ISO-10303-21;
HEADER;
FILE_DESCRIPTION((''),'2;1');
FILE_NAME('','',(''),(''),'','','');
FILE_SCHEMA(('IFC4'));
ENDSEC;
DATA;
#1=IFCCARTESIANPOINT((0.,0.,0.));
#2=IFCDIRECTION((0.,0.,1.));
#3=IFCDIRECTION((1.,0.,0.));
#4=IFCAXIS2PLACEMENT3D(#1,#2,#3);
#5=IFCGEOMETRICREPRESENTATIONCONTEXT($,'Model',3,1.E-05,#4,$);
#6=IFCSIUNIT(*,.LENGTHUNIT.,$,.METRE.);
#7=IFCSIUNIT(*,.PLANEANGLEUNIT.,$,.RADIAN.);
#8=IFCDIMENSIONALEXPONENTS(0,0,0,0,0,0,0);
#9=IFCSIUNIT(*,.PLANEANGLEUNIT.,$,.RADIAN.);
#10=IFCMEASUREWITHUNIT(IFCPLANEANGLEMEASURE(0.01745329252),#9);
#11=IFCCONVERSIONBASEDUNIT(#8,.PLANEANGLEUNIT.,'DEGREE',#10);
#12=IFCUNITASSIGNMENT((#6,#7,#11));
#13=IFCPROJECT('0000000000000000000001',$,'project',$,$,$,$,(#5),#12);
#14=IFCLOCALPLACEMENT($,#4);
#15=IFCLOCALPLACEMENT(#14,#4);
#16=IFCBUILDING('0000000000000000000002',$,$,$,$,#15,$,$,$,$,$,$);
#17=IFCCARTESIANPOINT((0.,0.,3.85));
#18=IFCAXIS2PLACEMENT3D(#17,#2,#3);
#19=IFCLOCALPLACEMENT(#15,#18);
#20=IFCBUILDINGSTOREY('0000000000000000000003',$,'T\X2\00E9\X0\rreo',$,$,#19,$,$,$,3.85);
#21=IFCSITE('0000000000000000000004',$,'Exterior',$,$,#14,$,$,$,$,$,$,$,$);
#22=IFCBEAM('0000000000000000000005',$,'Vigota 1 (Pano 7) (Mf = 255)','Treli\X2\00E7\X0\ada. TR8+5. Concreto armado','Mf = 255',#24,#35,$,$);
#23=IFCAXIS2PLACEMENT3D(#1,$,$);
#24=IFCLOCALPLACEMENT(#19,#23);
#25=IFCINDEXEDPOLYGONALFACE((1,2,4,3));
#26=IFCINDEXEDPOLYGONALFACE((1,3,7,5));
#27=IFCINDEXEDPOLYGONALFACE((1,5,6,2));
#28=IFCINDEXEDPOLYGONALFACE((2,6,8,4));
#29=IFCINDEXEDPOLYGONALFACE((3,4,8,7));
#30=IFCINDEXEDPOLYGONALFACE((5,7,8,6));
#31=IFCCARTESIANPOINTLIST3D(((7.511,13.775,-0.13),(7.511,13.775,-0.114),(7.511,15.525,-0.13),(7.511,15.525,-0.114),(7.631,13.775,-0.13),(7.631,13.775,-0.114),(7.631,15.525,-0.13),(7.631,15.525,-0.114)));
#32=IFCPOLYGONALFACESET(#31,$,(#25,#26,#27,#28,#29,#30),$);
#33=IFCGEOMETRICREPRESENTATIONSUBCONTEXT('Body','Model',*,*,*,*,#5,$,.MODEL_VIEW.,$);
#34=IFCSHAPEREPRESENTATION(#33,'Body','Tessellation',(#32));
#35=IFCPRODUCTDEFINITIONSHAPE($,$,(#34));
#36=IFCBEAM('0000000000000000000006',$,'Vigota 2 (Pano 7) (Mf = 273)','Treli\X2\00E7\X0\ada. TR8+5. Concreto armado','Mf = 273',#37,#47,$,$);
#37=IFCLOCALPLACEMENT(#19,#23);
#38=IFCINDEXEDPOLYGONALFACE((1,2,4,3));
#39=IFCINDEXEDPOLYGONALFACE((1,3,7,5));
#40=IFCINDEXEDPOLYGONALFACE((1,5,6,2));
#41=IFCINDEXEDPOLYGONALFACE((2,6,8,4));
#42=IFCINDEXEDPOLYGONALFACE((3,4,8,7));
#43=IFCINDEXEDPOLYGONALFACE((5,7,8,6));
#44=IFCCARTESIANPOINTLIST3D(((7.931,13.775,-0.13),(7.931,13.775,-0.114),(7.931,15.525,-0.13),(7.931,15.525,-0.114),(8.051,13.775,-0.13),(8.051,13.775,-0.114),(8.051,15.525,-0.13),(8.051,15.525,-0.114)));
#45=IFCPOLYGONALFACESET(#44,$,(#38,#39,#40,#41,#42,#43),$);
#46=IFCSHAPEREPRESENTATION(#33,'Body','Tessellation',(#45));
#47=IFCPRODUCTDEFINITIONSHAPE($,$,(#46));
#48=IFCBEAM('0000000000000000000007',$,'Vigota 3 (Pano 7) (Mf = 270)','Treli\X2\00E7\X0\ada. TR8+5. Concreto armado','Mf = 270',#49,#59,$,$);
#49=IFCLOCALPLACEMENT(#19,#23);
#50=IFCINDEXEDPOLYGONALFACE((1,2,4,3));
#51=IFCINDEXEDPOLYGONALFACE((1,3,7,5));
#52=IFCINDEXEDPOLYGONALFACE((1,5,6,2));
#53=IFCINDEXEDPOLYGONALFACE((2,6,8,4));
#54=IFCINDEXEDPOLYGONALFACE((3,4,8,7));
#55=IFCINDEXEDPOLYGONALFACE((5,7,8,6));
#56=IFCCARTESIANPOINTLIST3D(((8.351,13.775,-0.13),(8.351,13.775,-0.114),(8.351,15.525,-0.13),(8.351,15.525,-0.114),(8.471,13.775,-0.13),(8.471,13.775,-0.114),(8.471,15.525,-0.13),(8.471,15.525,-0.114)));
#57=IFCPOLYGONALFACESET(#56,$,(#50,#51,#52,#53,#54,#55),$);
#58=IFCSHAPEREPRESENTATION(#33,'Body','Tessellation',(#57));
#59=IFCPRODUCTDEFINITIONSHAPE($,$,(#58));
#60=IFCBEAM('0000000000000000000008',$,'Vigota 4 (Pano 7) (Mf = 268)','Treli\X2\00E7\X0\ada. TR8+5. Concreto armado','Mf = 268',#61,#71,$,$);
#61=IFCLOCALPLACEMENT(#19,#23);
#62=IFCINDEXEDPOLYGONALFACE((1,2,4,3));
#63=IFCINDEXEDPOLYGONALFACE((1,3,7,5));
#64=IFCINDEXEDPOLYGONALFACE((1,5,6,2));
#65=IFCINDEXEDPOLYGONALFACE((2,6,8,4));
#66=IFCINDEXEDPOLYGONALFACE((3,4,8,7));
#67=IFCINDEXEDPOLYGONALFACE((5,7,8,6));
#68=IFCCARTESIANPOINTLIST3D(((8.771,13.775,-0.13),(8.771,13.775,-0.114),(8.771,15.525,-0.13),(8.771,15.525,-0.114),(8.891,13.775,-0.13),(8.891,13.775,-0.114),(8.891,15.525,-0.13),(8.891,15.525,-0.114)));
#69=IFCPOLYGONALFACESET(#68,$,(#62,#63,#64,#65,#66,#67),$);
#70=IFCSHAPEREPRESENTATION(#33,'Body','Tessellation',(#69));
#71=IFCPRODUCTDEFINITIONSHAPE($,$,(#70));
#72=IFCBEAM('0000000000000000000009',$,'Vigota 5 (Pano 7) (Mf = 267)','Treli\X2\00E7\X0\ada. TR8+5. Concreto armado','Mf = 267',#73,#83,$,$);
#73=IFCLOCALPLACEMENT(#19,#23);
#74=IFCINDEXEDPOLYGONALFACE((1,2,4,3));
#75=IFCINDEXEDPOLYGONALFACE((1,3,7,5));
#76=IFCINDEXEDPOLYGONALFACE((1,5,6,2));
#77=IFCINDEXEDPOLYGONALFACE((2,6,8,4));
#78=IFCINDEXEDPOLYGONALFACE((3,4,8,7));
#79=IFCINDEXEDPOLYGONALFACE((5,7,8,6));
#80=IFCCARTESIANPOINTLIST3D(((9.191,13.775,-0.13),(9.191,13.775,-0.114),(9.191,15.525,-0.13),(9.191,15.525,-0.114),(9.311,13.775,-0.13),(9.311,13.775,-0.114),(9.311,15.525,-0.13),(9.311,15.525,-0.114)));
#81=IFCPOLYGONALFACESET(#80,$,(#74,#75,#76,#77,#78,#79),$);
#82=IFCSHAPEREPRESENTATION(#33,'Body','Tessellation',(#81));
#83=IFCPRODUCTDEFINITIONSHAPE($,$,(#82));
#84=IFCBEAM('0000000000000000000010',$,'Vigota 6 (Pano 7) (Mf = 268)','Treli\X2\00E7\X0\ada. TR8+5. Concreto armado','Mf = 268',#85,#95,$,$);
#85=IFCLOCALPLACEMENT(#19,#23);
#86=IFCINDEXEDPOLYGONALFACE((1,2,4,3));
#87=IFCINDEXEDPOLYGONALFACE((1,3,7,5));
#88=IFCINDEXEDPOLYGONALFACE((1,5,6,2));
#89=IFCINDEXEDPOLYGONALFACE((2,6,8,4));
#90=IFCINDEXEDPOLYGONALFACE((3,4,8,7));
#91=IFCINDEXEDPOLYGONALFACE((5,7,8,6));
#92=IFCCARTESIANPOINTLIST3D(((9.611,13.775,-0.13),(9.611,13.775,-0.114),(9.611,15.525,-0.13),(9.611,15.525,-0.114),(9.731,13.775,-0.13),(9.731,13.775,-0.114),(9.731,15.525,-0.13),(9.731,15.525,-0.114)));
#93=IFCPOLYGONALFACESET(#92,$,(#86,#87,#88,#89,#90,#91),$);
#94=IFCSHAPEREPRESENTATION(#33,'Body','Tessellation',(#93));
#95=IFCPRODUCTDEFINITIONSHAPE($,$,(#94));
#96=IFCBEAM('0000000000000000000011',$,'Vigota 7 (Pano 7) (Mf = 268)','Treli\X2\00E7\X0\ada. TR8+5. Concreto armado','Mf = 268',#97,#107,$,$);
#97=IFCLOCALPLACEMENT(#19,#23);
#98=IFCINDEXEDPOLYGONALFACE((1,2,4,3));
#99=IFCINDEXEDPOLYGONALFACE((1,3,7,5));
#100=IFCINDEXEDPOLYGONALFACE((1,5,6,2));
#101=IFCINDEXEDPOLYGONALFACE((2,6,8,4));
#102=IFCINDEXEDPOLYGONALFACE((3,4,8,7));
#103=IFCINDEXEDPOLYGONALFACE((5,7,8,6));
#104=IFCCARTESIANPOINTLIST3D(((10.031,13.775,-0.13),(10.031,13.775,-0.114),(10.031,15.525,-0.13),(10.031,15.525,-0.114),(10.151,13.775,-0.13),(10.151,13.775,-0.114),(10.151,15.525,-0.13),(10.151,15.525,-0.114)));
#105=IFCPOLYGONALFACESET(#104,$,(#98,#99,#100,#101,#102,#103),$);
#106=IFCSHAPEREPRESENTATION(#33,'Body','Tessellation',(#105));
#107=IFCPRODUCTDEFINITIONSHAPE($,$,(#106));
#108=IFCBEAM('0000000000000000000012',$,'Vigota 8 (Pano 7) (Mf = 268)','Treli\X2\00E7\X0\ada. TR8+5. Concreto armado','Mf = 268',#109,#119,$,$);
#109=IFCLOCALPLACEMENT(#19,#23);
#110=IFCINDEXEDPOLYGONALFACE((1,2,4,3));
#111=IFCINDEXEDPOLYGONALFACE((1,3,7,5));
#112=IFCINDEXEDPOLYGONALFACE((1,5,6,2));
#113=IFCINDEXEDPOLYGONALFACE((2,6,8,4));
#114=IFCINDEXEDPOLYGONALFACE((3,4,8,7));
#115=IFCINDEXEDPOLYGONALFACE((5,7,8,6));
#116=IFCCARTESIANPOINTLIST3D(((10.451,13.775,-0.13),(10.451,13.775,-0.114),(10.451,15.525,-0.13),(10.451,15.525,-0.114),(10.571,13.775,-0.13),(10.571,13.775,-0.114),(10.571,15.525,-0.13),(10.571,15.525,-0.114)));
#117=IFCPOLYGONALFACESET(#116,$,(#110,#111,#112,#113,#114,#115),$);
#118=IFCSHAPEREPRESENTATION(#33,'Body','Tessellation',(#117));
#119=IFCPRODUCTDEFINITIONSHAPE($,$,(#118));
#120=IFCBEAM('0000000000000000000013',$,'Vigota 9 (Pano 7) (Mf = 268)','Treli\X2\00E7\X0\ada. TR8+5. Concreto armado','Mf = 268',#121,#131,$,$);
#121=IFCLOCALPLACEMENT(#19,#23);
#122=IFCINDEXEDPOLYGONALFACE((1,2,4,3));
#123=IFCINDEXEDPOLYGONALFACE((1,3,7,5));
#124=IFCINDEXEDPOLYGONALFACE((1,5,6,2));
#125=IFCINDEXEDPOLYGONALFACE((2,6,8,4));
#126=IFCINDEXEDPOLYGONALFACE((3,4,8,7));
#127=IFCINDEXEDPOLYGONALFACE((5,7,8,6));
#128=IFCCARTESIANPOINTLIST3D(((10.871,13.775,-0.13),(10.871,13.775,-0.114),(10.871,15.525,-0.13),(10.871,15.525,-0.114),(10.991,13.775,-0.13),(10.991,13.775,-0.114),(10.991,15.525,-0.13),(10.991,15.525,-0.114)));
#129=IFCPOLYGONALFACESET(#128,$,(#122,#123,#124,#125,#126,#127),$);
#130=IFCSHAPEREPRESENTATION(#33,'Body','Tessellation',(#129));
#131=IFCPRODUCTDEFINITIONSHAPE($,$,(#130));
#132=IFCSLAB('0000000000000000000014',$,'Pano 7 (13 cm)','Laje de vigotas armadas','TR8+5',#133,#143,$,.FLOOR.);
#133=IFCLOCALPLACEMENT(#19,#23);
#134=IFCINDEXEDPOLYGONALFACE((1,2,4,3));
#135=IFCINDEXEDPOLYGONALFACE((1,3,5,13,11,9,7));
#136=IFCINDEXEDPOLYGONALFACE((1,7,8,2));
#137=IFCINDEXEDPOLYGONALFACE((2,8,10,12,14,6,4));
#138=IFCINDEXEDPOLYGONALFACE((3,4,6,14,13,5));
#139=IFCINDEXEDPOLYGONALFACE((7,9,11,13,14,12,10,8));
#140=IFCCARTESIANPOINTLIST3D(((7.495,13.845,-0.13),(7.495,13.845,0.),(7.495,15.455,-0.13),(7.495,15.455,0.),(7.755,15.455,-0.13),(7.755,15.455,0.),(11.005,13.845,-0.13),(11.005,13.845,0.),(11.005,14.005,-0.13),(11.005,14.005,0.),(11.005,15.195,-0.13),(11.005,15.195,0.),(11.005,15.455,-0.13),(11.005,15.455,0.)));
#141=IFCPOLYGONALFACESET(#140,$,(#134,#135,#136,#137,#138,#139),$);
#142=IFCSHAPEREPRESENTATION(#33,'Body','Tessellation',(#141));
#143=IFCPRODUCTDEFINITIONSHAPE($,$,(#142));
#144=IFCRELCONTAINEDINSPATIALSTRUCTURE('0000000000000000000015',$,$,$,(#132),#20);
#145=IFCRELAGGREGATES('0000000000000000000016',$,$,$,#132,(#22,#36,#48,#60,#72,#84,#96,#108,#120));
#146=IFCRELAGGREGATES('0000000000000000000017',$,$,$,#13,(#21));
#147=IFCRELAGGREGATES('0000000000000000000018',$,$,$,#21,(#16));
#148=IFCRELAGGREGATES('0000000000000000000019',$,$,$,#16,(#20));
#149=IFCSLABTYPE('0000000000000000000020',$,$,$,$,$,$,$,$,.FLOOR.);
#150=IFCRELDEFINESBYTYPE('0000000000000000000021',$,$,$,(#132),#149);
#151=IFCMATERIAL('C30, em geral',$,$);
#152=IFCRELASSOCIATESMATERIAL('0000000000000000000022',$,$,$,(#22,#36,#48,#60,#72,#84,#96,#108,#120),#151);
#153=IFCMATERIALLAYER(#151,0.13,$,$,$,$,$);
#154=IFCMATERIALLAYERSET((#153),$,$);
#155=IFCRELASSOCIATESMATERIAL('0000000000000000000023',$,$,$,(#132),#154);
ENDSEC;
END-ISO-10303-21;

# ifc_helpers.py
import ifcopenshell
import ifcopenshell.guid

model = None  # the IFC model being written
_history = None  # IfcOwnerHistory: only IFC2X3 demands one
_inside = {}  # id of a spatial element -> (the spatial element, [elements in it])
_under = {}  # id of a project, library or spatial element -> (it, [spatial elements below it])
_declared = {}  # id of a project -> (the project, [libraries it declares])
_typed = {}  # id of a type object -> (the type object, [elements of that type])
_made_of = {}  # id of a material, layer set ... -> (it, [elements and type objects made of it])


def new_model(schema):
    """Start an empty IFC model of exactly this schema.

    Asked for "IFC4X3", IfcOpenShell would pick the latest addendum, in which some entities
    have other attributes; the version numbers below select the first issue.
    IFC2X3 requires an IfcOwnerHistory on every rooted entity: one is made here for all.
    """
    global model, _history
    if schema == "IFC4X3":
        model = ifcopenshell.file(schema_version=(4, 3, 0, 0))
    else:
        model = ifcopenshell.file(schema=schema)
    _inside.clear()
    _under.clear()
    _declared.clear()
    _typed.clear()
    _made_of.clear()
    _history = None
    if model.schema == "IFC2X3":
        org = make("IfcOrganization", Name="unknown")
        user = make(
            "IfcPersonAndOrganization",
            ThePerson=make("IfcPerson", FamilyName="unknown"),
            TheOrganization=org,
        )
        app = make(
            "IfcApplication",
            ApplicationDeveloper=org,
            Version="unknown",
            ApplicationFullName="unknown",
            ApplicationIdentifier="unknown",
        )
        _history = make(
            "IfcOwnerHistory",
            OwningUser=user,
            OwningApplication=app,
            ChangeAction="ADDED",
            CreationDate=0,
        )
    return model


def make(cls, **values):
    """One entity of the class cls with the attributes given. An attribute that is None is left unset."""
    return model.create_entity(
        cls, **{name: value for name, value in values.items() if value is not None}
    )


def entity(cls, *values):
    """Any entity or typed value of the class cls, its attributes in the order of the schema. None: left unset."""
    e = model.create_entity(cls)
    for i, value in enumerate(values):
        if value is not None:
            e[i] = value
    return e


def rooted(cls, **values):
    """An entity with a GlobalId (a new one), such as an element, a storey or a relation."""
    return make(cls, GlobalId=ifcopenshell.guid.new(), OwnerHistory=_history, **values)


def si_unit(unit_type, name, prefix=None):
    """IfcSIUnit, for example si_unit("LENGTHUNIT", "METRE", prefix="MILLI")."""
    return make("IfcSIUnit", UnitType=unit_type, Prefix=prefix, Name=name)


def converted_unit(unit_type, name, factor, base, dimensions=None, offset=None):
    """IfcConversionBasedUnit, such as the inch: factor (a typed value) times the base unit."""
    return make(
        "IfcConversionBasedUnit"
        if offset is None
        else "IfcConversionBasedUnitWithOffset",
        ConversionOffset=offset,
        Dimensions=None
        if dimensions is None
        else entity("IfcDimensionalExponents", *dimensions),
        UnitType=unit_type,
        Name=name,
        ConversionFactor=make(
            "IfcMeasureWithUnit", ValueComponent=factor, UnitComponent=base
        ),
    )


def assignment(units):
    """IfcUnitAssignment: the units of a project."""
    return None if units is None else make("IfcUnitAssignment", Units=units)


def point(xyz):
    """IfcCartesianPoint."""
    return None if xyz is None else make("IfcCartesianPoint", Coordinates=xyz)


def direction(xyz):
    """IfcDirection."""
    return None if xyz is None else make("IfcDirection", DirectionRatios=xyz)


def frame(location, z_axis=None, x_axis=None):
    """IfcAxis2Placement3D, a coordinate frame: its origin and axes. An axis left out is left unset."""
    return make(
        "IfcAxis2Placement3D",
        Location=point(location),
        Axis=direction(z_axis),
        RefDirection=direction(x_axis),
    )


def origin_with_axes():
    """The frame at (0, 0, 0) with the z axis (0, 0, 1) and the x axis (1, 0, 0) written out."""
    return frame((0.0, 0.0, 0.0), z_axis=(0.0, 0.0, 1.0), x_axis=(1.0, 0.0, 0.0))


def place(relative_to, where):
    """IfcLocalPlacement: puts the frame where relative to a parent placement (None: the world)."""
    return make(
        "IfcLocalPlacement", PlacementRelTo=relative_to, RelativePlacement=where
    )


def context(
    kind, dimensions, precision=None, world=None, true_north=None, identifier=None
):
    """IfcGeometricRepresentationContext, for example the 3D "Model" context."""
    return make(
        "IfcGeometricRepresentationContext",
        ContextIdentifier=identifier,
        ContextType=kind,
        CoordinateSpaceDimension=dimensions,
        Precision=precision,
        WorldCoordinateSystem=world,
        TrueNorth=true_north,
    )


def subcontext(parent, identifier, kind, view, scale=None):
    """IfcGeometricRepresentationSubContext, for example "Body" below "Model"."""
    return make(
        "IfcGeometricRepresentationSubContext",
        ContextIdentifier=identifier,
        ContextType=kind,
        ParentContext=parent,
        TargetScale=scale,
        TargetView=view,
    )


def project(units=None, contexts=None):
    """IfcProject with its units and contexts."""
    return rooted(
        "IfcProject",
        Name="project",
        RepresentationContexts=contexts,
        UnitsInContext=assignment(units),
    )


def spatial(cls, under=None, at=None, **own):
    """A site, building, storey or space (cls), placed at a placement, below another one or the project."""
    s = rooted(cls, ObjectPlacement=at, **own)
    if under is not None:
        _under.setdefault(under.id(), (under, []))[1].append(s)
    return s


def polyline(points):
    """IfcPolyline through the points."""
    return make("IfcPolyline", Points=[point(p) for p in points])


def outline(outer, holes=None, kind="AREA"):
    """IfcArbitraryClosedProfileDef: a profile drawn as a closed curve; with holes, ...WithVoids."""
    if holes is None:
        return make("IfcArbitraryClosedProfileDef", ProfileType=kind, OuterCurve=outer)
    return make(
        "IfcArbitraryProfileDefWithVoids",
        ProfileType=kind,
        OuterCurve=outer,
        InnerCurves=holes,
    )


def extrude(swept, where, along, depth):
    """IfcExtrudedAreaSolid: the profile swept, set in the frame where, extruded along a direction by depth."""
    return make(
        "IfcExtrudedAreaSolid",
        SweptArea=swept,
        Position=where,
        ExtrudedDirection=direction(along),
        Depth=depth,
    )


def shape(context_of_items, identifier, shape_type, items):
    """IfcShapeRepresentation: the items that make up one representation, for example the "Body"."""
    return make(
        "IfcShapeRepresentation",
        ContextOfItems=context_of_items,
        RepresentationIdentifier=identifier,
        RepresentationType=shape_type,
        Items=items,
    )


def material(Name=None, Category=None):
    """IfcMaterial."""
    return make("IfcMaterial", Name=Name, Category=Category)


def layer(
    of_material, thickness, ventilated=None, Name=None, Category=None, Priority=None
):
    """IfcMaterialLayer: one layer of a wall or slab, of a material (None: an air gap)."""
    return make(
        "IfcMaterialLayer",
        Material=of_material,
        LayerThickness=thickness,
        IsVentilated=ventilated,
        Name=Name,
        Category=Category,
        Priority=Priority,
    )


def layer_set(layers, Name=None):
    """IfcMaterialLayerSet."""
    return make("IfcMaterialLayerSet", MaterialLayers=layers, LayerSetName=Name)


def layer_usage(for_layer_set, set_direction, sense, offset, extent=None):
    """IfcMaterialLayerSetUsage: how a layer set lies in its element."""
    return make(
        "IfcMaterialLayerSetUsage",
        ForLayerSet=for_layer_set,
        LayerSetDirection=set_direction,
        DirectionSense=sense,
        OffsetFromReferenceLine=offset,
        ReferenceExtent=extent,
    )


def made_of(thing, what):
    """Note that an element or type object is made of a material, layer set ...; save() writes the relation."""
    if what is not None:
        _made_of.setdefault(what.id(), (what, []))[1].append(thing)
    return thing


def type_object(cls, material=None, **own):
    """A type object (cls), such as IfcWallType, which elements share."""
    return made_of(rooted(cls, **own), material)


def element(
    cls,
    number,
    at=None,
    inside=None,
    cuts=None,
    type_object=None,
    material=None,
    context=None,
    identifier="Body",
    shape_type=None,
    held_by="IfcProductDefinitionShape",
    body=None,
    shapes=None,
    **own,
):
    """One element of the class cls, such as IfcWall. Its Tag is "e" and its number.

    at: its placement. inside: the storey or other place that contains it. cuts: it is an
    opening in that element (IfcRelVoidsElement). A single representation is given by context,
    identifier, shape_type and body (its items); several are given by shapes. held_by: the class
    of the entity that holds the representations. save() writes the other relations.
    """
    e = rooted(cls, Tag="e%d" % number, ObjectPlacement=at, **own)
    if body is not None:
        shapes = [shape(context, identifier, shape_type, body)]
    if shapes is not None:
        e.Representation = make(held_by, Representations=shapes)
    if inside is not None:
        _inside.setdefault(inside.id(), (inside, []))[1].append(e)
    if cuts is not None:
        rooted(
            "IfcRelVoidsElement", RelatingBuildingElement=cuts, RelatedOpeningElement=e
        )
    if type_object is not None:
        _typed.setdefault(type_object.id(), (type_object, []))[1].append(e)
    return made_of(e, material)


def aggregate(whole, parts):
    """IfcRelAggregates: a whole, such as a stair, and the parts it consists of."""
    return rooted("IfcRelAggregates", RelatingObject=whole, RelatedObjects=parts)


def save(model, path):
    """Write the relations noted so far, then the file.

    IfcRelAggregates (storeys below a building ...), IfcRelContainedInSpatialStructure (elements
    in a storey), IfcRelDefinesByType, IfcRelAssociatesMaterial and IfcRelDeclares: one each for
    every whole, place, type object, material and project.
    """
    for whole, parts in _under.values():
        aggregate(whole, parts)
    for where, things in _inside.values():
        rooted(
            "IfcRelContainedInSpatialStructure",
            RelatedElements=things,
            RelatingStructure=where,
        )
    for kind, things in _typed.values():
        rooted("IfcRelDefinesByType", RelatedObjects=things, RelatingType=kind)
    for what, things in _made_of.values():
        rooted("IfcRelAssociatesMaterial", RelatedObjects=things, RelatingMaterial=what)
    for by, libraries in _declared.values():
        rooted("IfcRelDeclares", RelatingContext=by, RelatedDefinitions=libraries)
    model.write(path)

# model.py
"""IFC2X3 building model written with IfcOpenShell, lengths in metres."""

from ifc_helpers import new_model, entity, si_unit, converted_unit, frame, origin_with_axes, place, context, subcontext, project, spatial, polyline, outline, extrude, material, layer, layer_set, layer_usage, type_object, element, aggregate, save


model = new_model("IFC2X3")

# Units and contexts
model_context = context("Model", 3, precision=1e-05, world=origin_with_axes())
body_context = subcontext(model_context, "Body", "Model", "MODEL_VIEW")
ifc_project = project(units=[si_unit("LENGTHUNIT", "METRE"), si_unit("PLANEANGLEUNIT", "RADIAN"), converted_unit("PLANEANGLEUNIT", "DEGREE", entity("IfcPlaneAngleMeasure", 0.01745329252), si_unit("PLANEANGLEUNIT", "RADIAN"), dimensions=[0, 0, 0, 0, 0, 0, 0])], contexts=[model_context])

# Beams
ifc_material = material(Name="C30, em geral")
site_placement = place(None, origin_with_axes())
building_placement = place(site_placement, origin_with_axes())
storey_placement = place(building_placement, frame((0.0, 0.0, 3.85), z_axis=(0.0, 0.0, 1.0), x_axis=(1.0, 0.0, 0.0)))
beam_1_placement = place(storey_placement, frame((7.571, 13.775, -0.122), z_axis=(0.0, 1.0, 0.0), x_axis=(-1.0, 0.0, 0.0)))
beam_1 = element("IfcBeam", 1, at=beam_1_placement, material=ifc_material, Name="Vigota 1 (Pano 7) (Mf = 255)", Description="Treliçada. TR8+5. Concreto armado", ObjectType="Mf = 255", context=body_context, shape_type="SweptSolid", body=[
    extrude(outline(polyline([(0.06, 0.008), (-0.06, 0.008), (-0.06, -0.008), (0.06, -0.008), (0.06, 0.008)])), origin_with_axes(), (0.0, 0.0, 1.0), 1.75),
])
beam_2_placement = place(storey_placement, frame((7.991, 13.775, -0.122), z_axis=(0.0, 1.0, 0.0), x_axis=(-1.0, 0.0, 0.0)))
beam_2 = element("IfcBeam", 2, at=beam_2_placement, material=ifc_material, Name="Vigota 2 (Pano 7) (Mf = 273)", Description="Treliçada. TR8+5. Concreto armado", ObjectType="Mf = 273", context=body_context, shape_type="SweptSolid", body=[
    extrude(outline(polyline([(0.06, 0.008), (-0.06, 0.008), (-0.06, -0.008), (0.06, -0.008), (0.06, 0.008)])), origin_with_axes(), (0.0, 0.0, 1.0), 1.75),
])
beam_3_placement = place(storey_placement, frame((8.411, 13.775, -0.122), z_axis=(0.0, 1.0, 0.0), x_axis=(-1.0, 0.0, 0.0)))
beam_3 = element("IfcBeam", 3, at=beam_3_placement, material=ifc_material, Name="Vigota 3 (Pano 7) (Mf = 270)", Description="Treliçada. TR8+5. Concreto armado", ObjectType="Mf = 270", context=body_context, shape_type="SweptSolid", body=[
    extrude(outline(polyline([(0.06, 0.008), (-0.06, 0.008), (-0.06, -0.008), (0.06, -0.008), (0.06, 0.008)])), origin_with_axes(), (0.0, 0.0, 1.0), 1.75),
])
beam_4_placement = place(storey_placement, frame((8.831, 13.775, -0.122), z_axis=(0.0, 1.0, 0.0), x_axis=(-1.0, 0.0, 0.0)))
beam_4 = element("IfcBeam", 4, at=beam_4_placement, material=ifc_material, Name="Vigota 4 (Pano 7) (Mf = 268)", Description="Treliçada. TR8+5. Concreto armado", ObjectType="Mf = 268", context=body_context, shape_type="SweptSolid", body=[
    extrude(outline(polyline([(0.06, 0.008), (-0.06, 0.008), (-0.06, -0.008), (0.06, -0.008), (0.06, 0.008)])), origin_with_axes(), (0.0, 0.0, 1.0), 1.75),
])
beam_5_placement = place(storey_placement, frame((9.251, 13.775, -0.122), z_axis=(0.0, 1.0, 0.0), x_axis=(-1.0, 0.0, 0.0)))
beam_5 = element("IfcBeam", 5, at=beam_5_placement, material=ifc_material, Name="Vigota 5 (Pano 7) (Mf = 267)", Description="Treliçada. TR8+5. Concreto armado", ObjectType="Mf = 267", context=body_context, shape_type="SweptSolid", body=[
    extrude(outline(polyline([(0.06, 0.008), (-0.06, 0.008), (-0.06, -0.008), (0.06, -0.008), (0.06, 0.008)])), origin_with_axes(), (0.0, 0.0, 1.0), 1.75),
])
beam_6_placement = place(storey_placement, frame((9.671, 13.775, -0.122), z_axis=(0.0, 1.0, 0.0), x_axis=(-1.0, 0.0, 0.0)))
beam_6 = element("IfcBeam", 6, at=beam_6_placement, material=ifc_material, Name="Vigota 6 (Pano 7) (Mf = 268)", Description="Treliçada. TR8+5. Concreto armado", ObjectType="Mf = 268", context=body_context, shape_type="SweptSolid", body=[
    extrude(outline(polyline([(0.06, 0.008), (-0.06, 0.008), (-0.06, -0.008), (0.06, -0.008), (0.06, 0.008)])), origin_with_axes(), (0.0, 0.0, 1.0), 1.75),
])
beam_7_placement = place(storey_placement, frame((10.091, 13.775, -0.122), z_axis=(0.0, 1.0, 0.0), x_axis=(-1.0, 0.0, 0.0)))
beam_7 = element("IfcBeam", 7, at=beam_7_placement, material=ifc_material, Name="Vigota 7 (Pano 7) (Mf = 268)", Description="Treliçada. TR8+5. Concreto armado", ObjectType="Mf = 268", context=body_context, shape_type="SweptSolid", body=[
    extrude(outline(polyline([(0.06, 0.008), (-0.06, 0.008), (-0.06, -0.008), (0.06, -0.008), (0.06, 0.008)])), origin_with_axes(), (0.0, 0.0, 1.0), 1.75),
])
beam_8_placement = place(storey_placement, frame((10.511, 13.775, -0.122), z_axis=(0.0, 1.0, 0.0), x_axis=(-1.0, 0.0, 0.0)))
beam_8 = element("IfcBeam", 8, at=beam_8_placement, material=ifc_material, Name="Vigota 8 (Pano 7) (Mf = 268)", Description="Treliçada. TR8+5. Concreto armado", ObjectType="Mf = 268", context=body_context, shape_type="SweptSolid", body=[
    extrude(outline(polyline([(0.06, 0.008), (-0.06, 0.008), (-0.06, -0.008), (0.06, -0.008), (0.06, 0.008)])), origin_with_axes(), (0.0, 0.0, 1.0), 1.75),
])
beam_9_placement = place(storey_placement, frame((10.931, 13.775, -0.122), z_axis=(0.0, 1.0, 0.0), x_axis=(-1.0, 0.0, 0.0)))
beam_9 = element("IfcBeam", 9, at=beam_9_placement, material=ifc_material, Name="Vigota 9 (Pano 7) (Mf = 268)", Description="Treliçada. TR8+5. Concreto armado", ObjectType="Mf = 268", context=body_context, shape_type="SweptSolid", body=[
    extrude(outline(polyline([(0.06, 0.008), (-0.06, 0.008), (-0.06, -0.008), (0.06, -0.008), (0.06, 0.008)])), origin_with_axes(), (0.0, 0.0, 1.0), 1.75),
])

# Site, building, storey
site = spatial("IfcSite", under=ifc_project, at=site_placement, Name="Exterior")
building = spatial("IfcBuilding", under=site, at=building_placement)
storey = spatial("IfcBuildingStorey", under=building, at=storey_placement, Name="Térreo", Elevation=3.85)

# Slab
slab_type = type_object("IfcSlabType", PredefinedType="FLOOR")
ifc_layer_1 = layer(ifc_material, 0.13)
ifc_layer_set_1 = layer_set([ifc_layer_1])
ifc_layer_usage_1 = layer_usage(ifc_layer_set_1, "AXIS3", "POSITIVE", 0.0)
slab_1_placement = place(storey_placement, frame((0.0, 0.0, -0.13), z_axis=(0.0, 0.0, 1.0), x_axis=(1.0, 0.0, 0.0)))
slab_1 = element("IfcSlab", 10, at=slab_1_placement, inside=storey, type_object=slab_type, material=ifc_layer_usage_1, Name="Pano 7 (13 cm)", Description="Laje de vigotas armadas", ObjectType="TR8+5", PredefinedType="FLOOR", context=body_context, shape_type="SweptSolid", body=[
    extrude(outline(polyline([(11.005, 15.455), (7.755, 15.455), (7.495, 15.455), (7.495, 13.845), (11.005, 13.845), (11.005, 14.005), (11.005, 15.195), (11.005, 15.455)])), origin_with_axes(), (0.0, 0.0, 1.0), 0.13),
])
aggregate(slab_1, [beam_1, beam_2, beam_3, beam_4, beam_5, beam_6, beam_7, beam_8, beam_9])

save(model, "model.ifc")
